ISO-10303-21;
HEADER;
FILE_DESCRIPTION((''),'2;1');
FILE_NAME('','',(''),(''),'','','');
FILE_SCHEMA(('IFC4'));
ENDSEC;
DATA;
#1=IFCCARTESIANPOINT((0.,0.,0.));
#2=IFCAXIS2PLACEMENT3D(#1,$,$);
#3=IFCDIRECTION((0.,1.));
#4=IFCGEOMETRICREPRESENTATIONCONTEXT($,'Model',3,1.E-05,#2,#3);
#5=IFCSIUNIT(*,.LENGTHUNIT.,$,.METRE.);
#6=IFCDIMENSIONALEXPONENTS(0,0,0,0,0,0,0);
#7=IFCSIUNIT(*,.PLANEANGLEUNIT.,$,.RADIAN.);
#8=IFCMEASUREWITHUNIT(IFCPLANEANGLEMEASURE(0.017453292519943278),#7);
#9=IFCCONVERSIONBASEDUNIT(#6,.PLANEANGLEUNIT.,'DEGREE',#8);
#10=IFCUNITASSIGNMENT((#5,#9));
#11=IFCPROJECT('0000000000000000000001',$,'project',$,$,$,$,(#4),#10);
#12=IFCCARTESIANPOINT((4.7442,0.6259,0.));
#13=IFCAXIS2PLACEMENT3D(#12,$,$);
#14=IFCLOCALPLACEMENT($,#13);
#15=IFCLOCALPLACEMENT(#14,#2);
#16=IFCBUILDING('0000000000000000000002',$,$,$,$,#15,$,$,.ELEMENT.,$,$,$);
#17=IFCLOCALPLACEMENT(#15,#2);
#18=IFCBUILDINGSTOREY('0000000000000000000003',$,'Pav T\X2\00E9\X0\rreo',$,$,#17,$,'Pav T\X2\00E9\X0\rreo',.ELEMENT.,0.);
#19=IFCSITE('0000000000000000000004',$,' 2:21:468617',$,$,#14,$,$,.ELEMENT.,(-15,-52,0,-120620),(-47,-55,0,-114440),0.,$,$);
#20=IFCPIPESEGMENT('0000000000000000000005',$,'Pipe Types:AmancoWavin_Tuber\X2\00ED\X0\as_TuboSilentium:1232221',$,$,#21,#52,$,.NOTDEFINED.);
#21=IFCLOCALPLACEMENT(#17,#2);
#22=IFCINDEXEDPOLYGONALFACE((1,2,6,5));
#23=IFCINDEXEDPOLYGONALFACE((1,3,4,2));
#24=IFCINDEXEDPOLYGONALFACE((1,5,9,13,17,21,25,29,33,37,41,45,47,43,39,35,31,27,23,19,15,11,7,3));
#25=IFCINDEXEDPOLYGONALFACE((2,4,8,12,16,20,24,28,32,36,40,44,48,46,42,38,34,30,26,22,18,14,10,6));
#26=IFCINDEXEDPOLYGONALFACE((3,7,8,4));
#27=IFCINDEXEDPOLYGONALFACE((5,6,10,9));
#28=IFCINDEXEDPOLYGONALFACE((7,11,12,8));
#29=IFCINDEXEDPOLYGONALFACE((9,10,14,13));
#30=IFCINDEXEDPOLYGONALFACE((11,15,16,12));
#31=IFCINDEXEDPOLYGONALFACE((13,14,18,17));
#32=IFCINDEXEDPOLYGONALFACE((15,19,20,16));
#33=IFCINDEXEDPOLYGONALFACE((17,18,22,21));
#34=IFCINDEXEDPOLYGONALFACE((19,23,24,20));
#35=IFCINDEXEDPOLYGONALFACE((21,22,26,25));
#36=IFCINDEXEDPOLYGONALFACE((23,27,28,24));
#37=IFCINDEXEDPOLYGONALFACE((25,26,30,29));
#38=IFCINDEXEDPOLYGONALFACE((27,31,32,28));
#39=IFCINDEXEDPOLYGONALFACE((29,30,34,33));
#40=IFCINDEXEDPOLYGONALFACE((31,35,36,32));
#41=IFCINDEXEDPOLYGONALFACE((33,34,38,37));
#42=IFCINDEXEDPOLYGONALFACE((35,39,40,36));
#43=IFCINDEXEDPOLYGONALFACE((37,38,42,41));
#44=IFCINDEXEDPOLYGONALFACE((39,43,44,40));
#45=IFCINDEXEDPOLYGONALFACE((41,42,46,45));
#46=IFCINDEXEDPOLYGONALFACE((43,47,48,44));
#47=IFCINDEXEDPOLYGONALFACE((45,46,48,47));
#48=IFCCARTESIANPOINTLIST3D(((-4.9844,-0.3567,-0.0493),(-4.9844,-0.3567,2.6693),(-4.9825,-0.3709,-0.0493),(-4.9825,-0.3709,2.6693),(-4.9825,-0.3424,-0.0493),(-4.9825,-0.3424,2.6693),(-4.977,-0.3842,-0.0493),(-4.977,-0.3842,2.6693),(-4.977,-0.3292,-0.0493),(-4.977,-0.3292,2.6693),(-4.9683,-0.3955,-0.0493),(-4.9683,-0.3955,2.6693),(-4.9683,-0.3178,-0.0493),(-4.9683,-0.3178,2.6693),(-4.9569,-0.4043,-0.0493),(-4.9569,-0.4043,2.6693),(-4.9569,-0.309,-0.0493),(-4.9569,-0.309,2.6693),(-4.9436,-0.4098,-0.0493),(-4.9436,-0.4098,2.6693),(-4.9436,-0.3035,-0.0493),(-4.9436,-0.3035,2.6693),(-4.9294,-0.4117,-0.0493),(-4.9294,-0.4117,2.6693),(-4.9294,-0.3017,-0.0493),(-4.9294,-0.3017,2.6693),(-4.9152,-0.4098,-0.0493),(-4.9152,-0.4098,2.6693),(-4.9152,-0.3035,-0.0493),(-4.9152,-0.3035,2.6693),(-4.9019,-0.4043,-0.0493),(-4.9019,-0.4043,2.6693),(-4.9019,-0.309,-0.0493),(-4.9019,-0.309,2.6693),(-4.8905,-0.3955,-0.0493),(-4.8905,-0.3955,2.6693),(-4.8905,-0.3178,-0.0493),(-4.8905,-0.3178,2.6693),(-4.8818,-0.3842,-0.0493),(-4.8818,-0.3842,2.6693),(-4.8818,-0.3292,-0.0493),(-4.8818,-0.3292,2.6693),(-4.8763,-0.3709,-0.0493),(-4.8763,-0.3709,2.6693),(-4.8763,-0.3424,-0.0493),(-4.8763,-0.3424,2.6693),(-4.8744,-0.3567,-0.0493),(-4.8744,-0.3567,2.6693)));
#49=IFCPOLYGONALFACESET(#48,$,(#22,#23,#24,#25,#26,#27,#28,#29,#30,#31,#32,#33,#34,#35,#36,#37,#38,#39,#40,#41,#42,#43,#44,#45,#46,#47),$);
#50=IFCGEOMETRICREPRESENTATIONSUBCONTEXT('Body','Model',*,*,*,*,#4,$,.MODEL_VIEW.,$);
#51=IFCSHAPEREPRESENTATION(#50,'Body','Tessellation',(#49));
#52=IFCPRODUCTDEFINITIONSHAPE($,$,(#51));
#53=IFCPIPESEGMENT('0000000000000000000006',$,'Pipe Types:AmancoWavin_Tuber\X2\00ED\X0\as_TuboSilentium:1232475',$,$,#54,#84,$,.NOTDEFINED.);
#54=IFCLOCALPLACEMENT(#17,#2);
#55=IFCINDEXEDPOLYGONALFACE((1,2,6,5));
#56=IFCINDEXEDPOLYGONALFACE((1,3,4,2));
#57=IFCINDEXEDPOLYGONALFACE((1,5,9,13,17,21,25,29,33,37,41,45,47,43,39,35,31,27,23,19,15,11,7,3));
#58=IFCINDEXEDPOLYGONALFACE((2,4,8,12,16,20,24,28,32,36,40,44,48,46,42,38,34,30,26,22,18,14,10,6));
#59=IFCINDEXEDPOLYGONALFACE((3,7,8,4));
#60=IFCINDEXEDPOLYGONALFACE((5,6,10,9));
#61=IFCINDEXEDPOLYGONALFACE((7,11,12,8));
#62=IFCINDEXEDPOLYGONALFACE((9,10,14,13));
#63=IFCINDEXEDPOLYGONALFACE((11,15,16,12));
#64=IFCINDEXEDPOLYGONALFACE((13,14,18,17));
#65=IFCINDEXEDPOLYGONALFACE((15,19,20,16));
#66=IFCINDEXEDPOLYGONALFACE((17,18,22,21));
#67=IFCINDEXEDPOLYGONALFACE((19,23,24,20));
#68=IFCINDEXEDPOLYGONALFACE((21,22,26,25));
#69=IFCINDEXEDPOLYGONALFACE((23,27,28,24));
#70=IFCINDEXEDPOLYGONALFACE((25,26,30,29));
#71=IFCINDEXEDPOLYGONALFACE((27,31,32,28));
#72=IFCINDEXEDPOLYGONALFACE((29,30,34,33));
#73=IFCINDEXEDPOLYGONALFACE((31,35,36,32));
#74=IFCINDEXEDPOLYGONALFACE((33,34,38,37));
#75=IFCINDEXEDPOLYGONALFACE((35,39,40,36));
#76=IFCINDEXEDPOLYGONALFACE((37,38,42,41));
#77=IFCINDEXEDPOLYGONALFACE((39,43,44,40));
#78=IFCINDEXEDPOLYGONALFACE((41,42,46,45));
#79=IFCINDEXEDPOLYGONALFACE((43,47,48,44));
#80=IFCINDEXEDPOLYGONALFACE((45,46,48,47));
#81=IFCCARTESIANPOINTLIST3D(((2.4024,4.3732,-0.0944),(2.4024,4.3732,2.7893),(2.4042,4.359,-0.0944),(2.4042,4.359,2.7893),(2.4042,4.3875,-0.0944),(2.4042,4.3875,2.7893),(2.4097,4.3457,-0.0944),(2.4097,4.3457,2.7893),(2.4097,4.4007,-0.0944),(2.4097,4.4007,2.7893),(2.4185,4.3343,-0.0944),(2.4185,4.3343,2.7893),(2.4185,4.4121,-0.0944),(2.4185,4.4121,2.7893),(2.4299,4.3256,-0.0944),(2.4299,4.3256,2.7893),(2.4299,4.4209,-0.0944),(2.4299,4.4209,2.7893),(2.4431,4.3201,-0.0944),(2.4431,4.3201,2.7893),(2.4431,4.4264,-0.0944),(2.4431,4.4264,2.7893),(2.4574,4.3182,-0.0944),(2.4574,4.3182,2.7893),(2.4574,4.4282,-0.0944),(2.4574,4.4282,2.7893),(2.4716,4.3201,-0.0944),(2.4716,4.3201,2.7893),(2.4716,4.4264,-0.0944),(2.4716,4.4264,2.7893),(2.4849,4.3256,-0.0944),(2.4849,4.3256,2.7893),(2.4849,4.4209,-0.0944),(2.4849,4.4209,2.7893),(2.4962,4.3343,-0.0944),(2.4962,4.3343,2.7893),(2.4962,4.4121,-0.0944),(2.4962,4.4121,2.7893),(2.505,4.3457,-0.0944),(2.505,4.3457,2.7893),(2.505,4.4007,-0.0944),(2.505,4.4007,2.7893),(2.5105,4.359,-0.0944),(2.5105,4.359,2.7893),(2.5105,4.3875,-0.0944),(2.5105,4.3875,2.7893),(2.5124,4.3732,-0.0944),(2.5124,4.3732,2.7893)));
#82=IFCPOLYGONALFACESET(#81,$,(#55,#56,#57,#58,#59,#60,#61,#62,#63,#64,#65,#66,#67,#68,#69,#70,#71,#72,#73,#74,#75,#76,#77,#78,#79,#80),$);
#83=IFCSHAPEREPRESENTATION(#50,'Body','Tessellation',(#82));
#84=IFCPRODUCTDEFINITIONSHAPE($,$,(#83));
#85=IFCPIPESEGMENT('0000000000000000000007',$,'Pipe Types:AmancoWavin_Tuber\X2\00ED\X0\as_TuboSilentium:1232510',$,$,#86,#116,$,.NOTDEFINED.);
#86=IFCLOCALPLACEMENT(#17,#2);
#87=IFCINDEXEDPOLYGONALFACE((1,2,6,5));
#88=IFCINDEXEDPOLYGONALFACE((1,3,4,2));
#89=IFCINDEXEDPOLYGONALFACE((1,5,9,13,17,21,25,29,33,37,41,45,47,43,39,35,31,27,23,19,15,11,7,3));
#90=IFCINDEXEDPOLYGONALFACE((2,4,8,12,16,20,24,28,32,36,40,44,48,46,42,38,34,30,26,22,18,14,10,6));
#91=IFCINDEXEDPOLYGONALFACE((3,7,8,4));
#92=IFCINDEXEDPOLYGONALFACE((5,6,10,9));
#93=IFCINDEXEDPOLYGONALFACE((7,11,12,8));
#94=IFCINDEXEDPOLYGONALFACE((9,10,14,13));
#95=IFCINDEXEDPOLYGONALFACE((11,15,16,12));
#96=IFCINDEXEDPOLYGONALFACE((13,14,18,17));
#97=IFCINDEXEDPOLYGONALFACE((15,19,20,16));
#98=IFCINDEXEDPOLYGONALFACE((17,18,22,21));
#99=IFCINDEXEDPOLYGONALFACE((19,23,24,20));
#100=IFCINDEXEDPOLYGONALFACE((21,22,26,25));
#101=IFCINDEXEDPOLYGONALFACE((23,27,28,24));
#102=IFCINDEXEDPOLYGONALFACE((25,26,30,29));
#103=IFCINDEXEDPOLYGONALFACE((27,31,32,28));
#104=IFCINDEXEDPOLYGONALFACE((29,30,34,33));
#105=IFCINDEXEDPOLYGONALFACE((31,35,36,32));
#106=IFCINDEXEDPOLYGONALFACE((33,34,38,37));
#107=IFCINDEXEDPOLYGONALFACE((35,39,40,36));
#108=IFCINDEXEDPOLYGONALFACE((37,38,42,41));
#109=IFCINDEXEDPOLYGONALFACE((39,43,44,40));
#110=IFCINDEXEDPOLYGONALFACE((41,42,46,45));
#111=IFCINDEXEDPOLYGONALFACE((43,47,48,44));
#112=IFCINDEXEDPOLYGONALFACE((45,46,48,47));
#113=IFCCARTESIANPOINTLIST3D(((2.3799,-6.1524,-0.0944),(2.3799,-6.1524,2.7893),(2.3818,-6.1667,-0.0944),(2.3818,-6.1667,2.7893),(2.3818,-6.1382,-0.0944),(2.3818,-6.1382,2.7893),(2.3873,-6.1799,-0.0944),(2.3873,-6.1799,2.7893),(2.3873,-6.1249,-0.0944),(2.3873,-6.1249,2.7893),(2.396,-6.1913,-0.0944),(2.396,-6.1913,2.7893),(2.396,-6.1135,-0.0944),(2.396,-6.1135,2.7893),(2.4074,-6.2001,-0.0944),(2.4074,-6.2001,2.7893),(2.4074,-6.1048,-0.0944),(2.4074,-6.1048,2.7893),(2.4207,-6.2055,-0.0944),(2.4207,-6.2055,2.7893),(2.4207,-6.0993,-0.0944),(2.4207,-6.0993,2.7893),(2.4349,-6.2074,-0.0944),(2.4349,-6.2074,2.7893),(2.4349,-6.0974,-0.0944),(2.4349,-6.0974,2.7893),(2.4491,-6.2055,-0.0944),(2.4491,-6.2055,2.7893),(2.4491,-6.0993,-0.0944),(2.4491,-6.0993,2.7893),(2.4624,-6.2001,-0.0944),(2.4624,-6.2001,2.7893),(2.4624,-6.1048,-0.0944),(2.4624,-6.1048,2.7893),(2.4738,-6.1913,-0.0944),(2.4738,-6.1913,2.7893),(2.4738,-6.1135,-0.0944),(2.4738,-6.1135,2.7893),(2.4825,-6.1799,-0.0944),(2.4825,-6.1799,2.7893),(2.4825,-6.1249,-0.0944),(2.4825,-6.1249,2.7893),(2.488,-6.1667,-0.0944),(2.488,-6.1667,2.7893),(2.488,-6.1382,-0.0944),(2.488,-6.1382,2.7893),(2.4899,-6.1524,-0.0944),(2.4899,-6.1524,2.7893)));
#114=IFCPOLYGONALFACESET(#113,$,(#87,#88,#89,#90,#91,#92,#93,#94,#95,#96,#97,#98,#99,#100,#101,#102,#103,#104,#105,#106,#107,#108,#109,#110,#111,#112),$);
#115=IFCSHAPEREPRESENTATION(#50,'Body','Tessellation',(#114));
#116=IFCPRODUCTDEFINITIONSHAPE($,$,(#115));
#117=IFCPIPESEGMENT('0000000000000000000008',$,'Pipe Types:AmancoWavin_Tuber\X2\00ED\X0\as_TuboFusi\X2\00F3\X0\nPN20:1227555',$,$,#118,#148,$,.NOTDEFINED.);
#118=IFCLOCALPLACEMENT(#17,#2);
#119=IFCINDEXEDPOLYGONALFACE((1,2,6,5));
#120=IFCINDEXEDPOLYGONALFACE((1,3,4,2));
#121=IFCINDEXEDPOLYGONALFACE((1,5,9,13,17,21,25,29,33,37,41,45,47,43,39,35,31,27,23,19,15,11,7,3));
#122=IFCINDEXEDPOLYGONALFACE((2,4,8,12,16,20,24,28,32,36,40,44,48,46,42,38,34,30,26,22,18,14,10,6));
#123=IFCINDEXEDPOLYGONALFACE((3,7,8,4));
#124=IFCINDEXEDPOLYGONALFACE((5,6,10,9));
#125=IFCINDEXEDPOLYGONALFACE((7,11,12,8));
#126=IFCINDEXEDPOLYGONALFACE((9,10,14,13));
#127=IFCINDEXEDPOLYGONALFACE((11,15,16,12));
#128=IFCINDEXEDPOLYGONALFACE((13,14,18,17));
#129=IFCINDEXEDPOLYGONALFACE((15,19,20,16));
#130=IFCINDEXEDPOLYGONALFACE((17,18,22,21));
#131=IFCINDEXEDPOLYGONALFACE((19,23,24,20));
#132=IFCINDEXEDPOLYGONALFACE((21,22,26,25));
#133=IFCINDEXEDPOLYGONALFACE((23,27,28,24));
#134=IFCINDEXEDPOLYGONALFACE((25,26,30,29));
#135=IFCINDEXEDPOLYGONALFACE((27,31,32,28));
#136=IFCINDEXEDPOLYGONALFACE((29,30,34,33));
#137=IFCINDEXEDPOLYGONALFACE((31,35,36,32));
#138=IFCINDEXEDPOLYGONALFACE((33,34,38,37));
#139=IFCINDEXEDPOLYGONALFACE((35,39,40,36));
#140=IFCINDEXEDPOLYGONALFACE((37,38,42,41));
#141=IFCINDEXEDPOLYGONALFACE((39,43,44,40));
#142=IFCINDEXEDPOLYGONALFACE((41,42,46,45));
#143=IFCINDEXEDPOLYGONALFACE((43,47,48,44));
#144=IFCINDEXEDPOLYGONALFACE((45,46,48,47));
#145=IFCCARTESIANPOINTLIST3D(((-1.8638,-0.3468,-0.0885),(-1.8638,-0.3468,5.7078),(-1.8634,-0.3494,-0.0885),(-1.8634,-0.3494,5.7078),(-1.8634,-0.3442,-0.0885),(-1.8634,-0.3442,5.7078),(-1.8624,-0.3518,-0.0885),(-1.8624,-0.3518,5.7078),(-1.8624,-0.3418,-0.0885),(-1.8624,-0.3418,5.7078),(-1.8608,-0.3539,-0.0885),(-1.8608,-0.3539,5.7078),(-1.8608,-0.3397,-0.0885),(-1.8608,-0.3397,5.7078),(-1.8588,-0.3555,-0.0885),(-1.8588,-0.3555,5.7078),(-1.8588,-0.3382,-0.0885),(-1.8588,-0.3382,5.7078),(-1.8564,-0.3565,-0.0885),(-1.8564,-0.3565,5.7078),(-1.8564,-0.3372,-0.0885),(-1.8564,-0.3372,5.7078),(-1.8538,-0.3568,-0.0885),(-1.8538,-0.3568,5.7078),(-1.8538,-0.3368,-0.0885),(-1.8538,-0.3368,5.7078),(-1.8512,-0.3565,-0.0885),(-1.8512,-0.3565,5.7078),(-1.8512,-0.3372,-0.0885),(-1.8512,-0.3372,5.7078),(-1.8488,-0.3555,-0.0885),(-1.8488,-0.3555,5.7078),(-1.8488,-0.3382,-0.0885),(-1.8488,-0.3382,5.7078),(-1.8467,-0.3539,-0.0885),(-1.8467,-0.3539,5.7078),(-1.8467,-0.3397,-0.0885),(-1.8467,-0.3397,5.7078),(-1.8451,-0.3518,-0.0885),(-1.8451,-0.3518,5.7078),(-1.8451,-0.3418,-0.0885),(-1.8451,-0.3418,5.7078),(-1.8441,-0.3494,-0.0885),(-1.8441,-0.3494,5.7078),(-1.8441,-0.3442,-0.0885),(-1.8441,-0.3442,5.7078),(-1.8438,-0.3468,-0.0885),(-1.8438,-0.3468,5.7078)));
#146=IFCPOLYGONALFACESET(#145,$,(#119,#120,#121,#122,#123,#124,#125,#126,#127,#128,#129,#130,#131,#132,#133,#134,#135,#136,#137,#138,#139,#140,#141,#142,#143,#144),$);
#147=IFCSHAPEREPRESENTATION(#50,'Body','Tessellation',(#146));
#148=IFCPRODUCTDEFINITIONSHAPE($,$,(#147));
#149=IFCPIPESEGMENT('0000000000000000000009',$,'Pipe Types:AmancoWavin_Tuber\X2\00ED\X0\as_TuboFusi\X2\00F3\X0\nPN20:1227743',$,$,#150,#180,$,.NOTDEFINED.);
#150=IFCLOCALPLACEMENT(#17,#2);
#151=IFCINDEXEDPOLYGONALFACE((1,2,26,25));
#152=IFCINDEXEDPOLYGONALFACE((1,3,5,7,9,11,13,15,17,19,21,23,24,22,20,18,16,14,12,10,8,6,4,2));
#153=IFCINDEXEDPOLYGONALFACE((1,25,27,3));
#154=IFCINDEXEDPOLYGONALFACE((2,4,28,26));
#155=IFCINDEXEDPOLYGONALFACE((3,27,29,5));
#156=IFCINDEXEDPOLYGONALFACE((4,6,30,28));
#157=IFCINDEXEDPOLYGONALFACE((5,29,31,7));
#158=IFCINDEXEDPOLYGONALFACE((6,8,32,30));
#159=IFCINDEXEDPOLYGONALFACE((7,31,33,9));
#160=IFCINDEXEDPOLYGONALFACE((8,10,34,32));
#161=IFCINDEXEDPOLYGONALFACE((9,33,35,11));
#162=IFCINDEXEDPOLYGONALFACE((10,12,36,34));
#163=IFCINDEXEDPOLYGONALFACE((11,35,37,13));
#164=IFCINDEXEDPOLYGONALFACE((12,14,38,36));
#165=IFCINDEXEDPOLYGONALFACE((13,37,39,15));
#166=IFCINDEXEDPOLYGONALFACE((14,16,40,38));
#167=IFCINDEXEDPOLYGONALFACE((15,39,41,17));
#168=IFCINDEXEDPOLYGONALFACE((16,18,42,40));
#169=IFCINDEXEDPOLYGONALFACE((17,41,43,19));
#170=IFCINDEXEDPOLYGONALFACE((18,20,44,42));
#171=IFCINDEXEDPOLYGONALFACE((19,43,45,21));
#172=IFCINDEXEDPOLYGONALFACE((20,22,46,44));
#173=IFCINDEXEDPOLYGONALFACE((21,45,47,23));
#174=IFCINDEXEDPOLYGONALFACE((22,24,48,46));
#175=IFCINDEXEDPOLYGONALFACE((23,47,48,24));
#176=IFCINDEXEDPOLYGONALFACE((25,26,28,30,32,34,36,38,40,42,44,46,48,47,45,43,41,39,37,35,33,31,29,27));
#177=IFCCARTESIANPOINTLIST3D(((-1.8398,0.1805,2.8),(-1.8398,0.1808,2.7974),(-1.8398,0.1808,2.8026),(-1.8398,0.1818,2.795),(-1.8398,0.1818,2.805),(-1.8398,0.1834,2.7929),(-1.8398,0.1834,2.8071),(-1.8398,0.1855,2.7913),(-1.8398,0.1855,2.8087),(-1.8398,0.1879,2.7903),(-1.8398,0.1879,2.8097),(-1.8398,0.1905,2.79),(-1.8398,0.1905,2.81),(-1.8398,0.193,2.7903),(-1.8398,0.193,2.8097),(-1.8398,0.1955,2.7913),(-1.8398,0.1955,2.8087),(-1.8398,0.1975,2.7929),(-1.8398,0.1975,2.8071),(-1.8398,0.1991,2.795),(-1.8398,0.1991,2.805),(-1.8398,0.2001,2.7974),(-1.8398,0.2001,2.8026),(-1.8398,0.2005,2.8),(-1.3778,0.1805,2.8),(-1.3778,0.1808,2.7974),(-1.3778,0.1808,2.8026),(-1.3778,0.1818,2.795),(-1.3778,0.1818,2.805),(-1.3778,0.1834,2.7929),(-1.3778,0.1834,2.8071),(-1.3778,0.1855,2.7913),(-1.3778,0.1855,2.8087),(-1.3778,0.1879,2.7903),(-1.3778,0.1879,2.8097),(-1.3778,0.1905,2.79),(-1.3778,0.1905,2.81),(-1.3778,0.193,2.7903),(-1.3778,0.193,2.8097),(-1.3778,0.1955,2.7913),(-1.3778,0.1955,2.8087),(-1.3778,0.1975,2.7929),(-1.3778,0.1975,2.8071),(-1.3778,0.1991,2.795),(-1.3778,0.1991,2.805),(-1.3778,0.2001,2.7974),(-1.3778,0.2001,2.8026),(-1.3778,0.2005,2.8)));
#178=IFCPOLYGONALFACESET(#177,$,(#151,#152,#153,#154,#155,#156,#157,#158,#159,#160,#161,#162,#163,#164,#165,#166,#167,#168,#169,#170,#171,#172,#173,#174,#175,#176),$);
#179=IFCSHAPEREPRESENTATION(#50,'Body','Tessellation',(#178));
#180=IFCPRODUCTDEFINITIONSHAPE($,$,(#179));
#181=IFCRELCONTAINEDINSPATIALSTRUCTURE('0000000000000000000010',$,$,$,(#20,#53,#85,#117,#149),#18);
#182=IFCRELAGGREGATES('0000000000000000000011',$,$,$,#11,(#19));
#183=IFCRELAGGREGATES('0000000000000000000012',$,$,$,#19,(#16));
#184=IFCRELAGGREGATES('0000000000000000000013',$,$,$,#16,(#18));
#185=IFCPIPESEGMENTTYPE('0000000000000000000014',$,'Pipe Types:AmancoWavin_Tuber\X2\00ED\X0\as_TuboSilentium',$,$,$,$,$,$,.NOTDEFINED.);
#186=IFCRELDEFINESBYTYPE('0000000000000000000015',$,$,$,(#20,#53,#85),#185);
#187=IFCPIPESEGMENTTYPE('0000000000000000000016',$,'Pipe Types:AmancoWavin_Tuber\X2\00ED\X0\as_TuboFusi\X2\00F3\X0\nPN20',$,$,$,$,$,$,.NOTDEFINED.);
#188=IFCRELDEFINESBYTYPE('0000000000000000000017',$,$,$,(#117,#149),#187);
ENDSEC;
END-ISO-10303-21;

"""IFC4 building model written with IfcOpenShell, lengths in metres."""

from ifc_helpers import new_model, entity, si_unit, converted_unit, direction, frame, origin, place, context, subcontext, project, spatial, arc, indexed_curve, outline, extrude, type_object, element, save


model = new_model("IFC4")

# Units and contexts
model_context = context("Model", 3, precision=1e-05, world=origin(), true_north=direction((0.0, 1.0)))
body_context = subcontext(model_context, "Body", "Model", "MODEL_VIEW")
ifc_project = project(units=[si_unit("LENGTHUNIT", "METRE"), converted_unit("PLANEANGLEUNIT", "DEGREE", entity("IfcPlaneAngleMeasure", 0.017453292519943278), si_unit("PLANEANGLEUNIT", "RADIAN"), dimensions=[0, 0, 0, 0, 0, 0, 0])], contexts=[model_context])

# Site, building, storey
site_placement = place(None, frame((4.7442, 0.6259, 0.0)))
site = spatial("IfcSite", under=ifc_project, at=site_placement, Name=" 2:21:468617", CompositionType="ELEMENT", RefLatitude=(-15, -52, 0, -120620), RefLongitude=(-47, -55, 0, -114440), RefElevation=0.0)
building_placement = place(site_placement, origin())
building = spatial("IfcBuilding", under=site, at=building_placement, CompositionType="ELEMENT")
storey_placement = place(building_placement, origin())
storey = spatial("IfcBuildingStorey", under=building, at=storey_placement, Name="Pav Térreo", LongName="Pav Térreo", CompositionType="ELEMENT", Elevation=0.0)

# Pipe segments
pipe_segment_type_1 = type_object("IfcPipeSegmentType", Name="Pipe Types:AmancoWavin_Tuberías_TuboSilentium", PredefinedType="NOTDEFINED")
pipe_segment_1_placement = place(storey_placement, origin())
element("IfcPipeSegment", 1, at=pipe_segment_1_placement, inside=storey, type_object=pipe_segment_type_1, Name="Pipe Types:AmancoWavin_Tuberías_TuboSilentium:1232221", PredefinedType="NOTDEFINED", context=body_context, shape_type="SweptSolid", body=[
    extrude(outline(indexed_curve([(0.055, 0.0), (0.0389, 0.0389), (0.0, 0.055), (-0.0389, 0.0389), (-0.055, 0.0), (-0.0389, -0.0389), (0.0, -0.055), (0.0389, -0.0389)], segments=[arc(1, 2, 3), arc(3, 4, 5), arc(5, 6, 7), arc(7, 8, 1)], self_intersect=False)), frame((-4.9294, -0.3567, -0.0493), z_axis=(0.0, 0.0, 1.0), x_axis=(-1.0, 0.0, 0.0)), (0.0, 0.0, 1.0), 2.7186),
])
pipe_segment_2_placement = place(storey_placement, origin())
element("IfcPipeSegment", 2, at=pipe_segment_2_placement, inside=storey, type_object=pipe_segment_type_1, Name="Pipe Types:AmancoWavin_Tuberías_TuboSilentium:1232475", PredefinedType="NOTDEFINED", context=body_context, shape_type="SweptSolid", body=[
    extrude(outline(indexed_curve([(0.055, 0.0), (0.0389, 0.0389), (0.0, 0.055), (-0.0389, 0.0389), (-0.055, 0.0), (-0.0389, -0.0389), (0.0, -0.055), (0.0389, -0.0389)], segments=[arc(1, 2, 3), arc(3, 4, 5), arc(5, 6, 7), arc(7, 8, 1)], self_intersect=False)), frame((2.4574, 4.3732, -0.0944), z_axis=(0.0, 0.0, 1.0), x_axis=(-1.0, 0.0, 0.0)), (0.0, 0.0, 1.0), 2.8837),
])
pipe_segment_3_placement = place(storey_placement, origin())
element("IfcPipeSegment", 3, at=pipe_segment_3_placement, inside=storey, type_object=pipe_segment_type_1, Name="Pipe Types:AmancoWavin_Tuberías_TuboSilentium:1232510", PredefinedType="NOTDEFINED", context=body_context, shape_type="SweptSolid", body=[
    extrude(outline(indexed_curve([(0.055, 0.0), (0.0389, 0.0389), (0.0, 0.055), (-0.0389, 0.0389), (-0.055, 0.0), (-0.0389, -0.0389), (0.0, -0.055), (0.0389, -0.0389)], segments=[arc(1, 2, 3), arc(3, 4, 5), arc(5, 6, 7), arc(7, 8, 1)], self_intersect=False)), frame((2.4349, -6.1524, -0.0944), z_axis=(0.0, 0.0, 1.0), x_axis=(-1.0, 0.0, 0.0)), (0.0, 0.0, 1.0), 2.8837),
])
pipe_segment_type_2 = type_object("IfcPipeSegmentType", Name="Pipe Types:AmancoWavin_Tuberías_TuboFusiónPN20", PredefinedType="NOTDEFINED")
pipe_segment_4_placement = place(storey_placement, origin())
element("IfcPipeSegment", 4, at=pipe_segment_4_placement, inside=storey, type_object=pipe_segment_type_2, Name="Pipe Types:AmancoWavin_Tuberías_TuboFusiónPN20:1227555", PredefinedType="NOTDEFINED", context=body_context, shape_type="SweptSolid", body=[
    extrude(outline(indexed_curve([(0.01, 0.0), (0.0071, 0.0071), (0.0, 0.01), (-0.0071, 0.0071), (-0.01, 0.0), (-0.0071, -0.0071), (0.0, -0.01), (0.0071, -0.0071)], segments=[arc(1, 2, 3), arc(3, 4, 5), arc(5, 6, 7), arc(7, 8, 1)], self_intersect=False)), frame((-1.8538, -0.3468, -0.0885), z_axis=(0.0, 0.0, 1.0), x_axis=(-1.0, 0.0, 0.0)), (0.0, 0.0, 1.0), 5.7963),
])
pipe_segment_5_placement = place(storey_placement, origin())
element("IfcPipeSegment", 5, at=pipe_segment_5_placement, inside=storey, type_object=pipe_segment_type_2, Name="Pipe Types:AmancoWavin_Tuberías_TuboFusiónPN20:1227743", PredefinedType="NOTDEFINED", context=body_context, shape_type="SweptSolid", body=[
    extrude(outline(indexed_curve([(0.01, 0.0), (0.0071, 0.0071), (0.0, 0.01), (-0.0071, 0.0071), (-0.01, 0.0), (-0.0071, -0.0071), (0.0, -0.01), (0.0071, -0.0071)], segments=[arc(1, 2, 3), arc(3, 4, 5), arc(5, 6, 7), arc(7, 8, 1)], self_intersect=False)), frame((-1.8398, 0.1905, 2.8), z_axis=(1.0, 0.0, 0.0), x_axis=(0.0, -1.0, 0.0)), (0.0, 0.0, 1.0), 0.462),
])

save(model, "model.ifc")
